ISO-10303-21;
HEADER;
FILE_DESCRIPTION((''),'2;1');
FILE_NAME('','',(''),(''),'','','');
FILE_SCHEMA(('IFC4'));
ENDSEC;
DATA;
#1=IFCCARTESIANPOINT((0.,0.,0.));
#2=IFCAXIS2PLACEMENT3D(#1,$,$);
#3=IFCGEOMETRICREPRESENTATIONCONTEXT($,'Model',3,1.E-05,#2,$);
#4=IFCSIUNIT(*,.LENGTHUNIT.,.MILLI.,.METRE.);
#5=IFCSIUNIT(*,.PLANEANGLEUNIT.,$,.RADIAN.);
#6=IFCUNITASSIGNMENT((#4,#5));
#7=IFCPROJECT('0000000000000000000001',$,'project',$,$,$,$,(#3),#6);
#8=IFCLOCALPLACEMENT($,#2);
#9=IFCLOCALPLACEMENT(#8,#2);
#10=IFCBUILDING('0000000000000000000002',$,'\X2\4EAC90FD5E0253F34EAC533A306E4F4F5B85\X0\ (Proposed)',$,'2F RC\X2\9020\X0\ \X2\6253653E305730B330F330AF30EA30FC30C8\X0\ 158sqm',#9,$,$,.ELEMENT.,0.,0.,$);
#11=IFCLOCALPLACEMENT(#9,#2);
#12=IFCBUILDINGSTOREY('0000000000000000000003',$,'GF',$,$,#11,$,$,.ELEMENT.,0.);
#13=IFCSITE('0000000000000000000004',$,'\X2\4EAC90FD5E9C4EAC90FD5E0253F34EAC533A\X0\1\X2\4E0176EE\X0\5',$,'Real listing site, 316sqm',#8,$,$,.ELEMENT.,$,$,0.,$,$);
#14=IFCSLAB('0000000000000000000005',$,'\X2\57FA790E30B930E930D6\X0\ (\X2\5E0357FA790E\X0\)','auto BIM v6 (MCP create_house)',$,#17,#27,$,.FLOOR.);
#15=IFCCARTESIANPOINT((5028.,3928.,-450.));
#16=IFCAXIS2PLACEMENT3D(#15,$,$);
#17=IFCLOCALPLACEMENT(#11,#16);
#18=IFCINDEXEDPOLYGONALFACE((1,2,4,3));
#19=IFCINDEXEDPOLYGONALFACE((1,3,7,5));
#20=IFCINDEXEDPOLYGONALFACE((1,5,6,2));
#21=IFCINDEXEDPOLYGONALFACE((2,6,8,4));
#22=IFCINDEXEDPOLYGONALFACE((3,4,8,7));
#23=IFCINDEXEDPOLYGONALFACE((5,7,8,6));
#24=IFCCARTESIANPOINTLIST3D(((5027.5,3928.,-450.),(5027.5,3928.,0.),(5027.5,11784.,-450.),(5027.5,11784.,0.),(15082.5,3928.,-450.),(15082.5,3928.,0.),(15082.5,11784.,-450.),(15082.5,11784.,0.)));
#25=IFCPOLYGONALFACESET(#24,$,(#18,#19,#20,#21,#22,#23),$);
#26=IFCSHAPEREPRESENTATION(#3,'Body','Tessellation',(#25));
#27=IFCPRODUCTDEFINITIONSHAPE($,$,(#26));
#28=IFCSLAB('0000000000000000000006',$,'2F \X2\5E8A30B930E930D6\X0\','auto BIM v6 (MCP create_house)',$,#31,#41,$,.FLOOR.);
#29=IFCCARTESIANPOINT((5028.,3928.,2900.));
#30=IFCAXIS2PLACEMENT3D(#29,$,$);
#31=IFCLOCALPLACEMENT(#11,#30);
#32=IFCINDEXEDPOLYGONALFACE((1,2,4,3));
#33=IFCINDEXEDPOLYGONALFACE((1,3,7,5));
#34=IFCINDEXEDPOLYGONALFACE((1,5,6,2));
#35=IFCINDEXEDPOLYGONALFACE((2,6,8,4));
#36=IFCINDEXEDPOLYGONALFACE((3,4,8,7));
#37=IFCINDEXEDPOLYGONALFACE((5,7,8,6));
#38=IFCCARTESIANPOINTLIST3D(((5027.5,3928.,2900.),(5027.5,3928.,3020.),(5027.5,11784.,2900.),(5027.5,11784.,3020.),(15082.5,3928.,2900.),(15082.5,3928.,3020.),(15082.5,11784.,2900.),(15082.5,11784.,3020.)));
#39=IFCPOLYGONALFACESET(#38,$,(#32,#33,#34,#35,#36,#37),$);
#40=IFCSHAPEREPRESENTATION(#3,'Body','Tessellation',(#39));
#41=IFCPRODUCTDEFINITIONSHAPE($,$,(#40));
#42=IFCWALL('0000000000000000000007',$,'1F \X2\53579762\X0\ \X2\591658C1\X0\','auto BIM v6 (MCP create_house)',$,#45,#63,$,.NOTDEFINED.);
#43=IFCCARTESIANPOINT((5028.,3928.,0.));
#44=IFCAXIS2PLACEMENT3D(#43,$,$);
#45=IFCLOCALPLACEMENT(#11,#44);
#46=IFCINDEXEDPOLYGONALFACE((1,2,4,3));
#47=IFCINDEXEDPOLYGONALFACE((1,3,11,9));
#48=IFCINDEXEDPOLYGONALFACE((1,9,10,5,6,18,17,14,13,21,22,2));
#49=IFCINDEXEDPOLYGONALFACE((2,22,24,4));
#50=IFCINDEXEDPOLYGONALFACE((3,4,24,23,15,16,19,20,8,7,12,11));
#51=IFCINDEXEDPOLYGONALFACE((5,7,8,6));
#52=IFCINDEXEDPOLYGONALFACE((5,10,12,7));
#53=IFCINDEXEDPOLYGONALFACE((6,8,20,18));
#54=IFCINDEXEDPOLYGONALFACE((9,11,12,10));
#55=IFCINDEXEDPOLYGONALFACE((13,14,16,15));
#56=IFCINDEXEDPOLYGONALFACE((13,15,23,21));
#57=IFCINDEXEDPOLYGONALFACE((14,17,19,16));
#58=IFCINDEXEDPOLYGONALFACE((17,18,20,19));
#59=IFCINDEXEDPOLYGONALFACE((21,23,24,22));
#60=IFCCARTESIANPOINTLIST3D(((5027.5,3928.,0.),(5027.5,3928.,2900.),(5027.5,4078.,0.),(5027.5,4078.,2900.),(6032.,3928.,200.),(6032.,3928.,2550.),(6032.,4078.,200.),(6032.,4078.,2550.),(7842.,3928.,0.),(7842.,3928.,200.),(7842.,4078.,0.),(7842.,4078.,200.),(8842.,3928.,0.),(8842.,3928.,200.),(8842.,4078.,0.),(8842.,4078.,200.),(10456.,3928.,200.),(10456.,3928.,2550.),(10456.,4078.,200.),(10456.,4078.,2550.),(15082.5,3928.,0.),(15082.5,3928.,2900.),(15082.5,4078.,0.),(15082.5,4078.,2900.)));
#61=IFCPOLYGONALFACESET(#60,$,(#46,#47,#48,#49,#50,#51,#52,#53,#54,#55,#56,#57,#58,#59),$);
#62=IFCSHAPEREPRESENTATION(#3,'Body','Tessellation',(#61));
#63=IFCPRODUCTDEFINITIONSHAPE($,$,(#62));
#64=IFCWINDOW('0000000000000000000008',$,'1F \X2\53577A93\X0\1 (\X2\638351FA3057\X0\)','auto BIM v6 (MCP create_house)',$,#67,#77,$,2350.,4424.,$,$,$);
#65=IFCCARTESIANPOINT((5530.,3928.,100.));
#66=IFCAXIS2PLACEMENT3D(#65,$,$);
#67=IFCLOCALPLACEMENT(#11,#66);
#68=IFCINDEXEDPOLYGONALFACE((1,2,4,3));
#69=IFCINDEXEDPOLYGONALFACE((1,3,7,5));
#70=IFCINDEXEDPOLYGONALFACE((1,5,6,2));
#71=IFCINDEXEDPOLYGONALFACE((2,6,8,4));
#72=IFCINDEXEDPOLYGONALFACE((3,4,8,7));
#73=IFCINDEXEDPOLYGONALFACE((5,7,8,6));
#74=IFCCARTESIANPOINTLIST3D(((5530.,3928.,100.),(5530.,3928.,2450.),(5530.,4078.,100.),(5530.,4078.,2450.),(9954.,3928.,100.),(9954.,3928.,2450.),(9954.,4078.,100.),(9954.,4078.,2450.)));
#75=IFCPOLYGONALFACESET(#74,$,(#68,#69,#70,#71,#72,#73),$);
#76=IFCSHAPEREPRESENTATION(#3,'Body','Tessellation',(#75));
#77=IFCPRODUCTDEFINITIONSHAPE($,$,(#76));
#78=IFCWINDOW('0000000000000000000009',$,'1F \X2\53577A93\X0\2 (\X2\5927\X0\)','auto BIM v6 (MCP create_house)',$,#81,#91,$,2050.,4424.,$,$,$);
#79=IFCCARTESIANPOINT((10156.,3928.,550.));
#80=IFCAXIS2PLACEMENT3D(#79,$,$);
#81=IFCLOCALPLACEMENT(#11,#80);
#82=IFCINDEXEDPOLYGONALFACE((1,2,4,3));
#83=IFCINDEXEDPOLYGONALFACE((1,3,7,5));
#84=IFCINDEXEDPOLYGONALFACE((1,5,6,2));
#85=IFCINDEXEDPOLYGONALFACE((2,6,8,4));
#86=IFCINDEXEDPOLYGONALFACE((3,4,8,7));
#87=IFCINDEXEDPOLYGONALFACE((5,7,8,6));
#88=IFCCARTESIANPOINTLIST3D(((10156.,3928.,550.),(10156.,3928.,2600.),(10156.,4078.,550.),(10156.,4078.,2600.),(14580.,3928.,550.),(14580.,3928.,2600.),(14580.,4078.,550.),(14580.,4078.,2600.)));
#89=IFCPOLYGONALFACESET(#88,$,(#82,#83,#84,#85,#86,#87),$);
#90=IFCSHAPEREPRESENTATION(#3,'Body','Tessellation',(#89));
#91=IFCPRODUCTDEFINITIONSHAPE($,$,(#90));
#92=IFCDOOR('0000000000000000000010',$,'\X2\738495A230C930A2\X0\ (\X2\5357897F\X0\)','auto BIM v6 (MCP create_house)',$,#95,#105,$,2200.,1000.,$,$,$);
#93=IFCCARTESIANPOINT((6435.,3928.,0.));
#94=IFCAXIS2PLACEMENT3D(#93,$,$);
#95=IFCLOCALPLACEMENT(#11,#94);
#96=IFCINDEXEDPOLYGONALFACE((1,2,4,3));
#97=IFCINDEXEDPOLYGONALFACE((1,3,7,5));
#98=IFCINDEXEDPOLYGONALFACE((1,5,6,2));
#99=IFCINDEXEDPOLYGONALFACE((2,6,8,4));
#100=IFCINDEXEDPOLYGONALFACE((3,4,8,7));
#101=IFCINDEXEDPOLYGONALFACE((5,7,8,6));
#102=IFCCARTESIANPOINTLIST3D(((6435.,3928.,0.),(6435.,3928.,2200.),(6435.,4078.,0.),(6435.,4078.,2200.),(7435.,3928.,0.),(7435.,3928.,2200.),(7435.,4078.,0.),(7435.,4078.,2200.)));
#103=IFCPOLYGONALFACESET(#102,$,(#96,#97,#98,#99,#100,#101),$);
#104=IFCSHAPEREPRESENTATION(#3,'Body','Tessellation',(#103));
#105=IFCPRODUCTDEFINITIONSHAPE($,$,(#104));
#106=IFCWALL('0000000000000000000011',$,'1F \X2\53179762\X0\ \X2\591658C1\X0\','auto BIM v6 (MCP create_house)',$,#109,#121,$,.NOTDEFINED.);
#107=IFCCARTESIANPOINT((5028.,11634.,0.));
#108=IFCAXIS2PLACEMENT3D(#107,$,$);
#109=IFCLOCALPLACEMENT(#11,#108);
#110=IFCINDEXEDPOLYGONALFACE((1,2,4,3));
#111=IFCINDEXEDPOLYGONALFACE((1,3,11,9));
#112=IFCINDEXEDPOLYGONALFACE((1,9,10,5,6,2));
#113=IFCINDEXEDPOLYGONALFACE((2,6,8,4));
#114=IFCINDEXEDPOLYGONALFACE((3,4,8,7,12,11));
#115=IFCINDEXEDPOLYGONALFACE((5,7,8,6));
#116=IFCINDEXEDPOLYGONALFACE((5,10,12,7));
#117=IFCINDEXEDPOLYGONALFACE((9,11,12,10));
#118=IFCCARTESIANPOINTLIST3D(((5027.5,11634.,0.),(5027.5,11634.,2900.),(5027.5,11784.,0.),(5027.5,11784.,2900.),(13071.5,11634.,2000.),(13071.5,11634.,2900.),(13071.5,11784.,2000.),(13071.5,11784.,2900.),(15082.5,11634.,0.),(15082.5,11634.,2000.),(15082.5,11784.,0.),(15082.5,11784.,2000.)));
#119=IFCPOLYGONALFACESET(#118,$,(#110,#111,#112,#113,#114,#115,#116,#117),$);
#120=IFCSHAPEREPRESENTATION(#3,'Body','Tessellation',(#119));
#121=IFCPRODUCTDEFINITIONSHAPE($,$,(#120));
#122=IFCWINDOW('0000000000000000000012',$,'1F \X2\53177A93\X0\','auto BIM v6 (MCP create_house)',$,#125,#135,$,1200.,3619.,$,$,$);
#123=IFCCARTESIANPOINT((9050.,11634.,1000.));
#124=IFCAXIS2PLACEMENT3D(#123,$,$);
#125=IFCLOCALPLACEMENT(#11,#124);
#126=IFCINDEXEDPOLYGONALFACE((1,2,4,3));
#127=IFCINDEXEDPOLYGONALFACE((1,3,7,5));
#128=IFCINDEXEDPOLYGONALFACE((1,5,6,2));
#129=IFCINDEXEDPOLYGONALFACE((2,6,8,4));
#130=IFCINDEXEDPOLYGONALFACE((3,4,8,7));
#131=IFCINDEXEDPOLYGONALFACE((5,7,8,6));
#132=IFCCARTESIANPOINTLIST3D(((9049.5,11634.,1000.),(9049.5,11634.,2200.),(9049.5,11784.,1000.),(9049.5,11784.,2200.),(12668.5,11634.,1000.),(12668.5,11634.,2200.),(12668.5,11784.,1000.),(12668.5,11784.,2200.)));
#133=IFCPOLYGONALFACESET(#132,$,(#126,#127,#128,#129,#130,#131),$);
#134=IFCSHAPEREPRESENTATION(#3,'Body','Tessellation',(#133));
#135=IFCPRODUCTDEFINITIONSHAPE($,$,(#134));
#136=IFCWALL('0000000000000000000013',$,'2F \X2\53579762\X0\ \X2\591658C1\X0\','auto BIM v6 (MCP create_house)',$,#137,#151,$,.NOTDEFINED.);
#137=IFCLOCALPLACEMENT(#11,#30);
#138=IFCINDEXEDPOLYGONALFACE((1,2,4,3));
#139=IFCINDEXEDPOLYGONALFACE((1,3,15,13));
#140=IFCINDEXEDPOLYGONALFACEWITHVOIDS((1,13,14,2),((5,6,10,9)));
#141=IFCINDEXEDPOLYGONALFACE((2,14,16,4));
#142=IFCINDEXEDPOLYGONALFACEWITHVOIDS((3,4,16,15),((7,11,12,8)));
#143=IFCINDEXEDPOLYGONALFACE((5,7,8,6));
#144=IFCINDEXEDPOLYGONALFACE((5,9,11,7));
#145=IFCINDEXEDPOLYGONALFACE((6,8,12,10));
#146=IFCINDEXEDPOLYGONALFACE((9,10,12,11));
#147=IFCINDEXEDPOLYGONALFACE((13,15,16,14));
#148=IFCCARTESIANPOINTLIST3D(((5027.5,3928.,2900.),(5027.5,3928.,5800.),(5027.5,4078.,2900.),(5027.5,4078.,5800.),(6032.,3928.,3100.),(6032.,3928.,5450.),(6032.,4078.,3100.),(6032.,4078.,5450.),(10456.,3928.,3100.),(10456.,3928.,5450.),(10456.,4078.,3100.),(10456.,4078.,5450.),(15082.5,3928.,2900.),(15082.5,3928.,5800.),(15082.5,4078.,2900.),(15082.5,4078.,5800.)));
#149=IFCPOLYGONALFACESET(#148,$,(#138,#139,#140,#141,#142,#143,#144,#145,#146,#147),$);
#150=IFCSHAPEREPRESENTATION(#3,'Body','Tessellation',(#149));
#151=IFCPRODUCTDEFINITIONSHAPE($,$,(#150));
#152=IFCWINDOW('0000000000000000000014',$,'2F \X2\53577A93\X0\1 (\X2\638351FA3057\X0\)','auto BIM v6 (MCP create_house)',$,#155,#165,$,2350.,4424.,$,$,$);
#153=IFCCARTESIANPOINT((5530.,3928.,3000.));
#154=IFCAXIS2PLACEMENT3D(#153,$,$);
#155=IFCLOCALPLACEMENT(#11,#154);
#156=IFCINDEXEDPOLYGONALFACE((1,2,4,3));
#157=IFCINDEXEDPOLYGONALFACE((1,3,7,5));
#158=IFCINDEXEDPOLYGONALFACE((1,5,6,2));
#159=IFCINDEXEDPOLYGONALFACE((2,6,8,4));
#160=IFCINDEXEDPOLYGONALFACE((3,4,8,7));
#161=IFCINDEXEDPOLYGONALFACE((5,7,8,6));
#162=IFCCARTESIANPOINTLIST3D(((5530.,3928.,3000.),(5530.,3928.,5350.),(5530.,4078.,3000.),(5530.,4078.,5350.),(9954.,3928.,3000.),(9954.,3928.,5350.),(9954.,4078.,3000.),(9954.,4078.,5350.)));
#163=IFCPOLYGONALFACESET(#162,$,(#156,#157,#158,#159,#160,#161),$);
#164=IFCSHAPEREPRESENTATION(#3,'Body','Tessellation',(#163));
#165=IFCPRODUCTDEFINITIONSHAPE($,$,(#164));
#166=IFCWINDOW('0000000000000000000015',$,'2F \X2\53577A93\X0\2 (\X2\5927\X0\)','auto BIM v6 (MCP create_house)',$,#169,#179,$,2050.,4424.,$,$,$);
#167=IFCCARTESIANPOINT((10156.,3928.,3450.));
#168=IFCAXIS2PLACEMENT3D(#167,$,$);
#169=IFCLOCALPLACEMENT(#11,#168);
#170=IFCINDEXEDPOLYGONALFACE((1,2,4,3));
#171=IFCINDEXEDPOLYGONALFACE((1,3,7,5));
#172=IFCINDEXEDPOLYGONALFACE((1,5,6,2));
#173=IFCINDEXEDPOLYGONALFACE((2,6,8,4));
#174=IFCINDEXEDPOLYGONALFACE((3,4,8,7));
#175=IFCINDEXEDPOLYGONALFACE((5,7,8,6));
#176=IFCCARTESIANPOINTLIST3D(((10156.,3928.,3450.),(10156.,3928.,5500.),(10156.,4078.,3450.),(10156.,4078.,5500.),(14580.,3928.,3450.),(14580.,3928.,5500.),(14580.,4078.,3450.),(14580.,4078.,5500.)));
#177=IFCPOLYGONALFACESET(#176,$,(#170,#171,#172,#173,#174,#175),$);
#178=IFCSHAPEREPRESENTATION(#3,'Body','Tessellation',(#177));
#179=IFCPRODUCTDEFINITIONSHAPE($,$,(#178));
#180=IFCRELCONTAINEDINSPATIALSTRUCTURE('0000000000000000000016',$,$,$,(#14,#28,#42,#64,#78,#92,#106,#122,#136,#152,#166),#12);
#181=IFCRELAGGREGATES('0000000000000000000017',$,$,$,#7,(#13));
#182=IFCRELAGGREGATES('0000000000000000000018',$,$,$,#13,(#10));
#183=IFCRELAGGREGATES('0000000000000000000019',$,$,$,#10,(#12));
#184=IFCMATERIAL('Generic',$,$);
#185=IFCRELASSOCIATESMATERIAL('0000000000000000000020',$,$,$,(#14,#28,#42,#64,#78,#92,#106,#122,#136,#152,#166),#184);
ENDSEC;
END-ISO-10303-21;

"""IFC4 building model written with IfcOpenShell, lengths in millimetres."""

from ifc_helpers import new_model, si_unit, frame, frame_2d, origin, place, context, project, spatial, rectangle, extrude, material, element, fill, save


model = new_model("IFC4")

# Units and contexts
model_context = context("Model", 3, precision=1e-05, world=origin())
ifc_project = project(units=[si_unit("LENGTHUNIT", "METRE", prefix="MILLI"), si_unit("PLANEANGLEUNIT", "RADIAN")], contexts=[model_context])

# Site, building, storey
site_placement = place(None, origin())
site = spatial("IfcSite", under=ifc_project, at=site_placement, Name="京都府京都市右京区1丁目5", ObjectType="Real listing site, 316sqm", CompositionType="ELEMENT", RefElevation=0.0)
building_placement = place(site_placement, origin())
building = spatial("IfcBuilding", under=site, at=building_placement, Name="京都市右京区の住宅 (Proposed)", ObjectType="2F RC造 打放しコンクリート 158sqm", CompositionType="ELEMENT", ElevationOfRefHeight=0.0, ElevationOfTerrain=0.0)
storey_placement = place(building_placement, origin())
storey = spatial("IfcBuildingStorey", under=building, at=storey_placement, Name="GF", CompositionType="ELEMENT", Elevation=0.0)

# Slabs
ifc_material = material(Name="Generic")
slab_1_placement = place(storey_placement, frame((5028.0, 3928.0, -450.0)))
element("IfcSlab", 1, at=slab_1_placement, inside=storey, material=ifc_material, Name="基礎スラブ (布基礎)", Description="auto BIM v6 (MCP create_house)", PredefinedType="FLOOR", context=model_context, shape_type="SweptSolid", body=[
    extrude(rectangle(XDim=10055.0, YDim=7856.0, at=frame_2d((5027.0, 3928.0))), frame((5028.0, 3928.0, -450.0)), (0.0, 0.0, 1.0), 450.0),
])
slab_2_placement = place(storey_placement, frame((5028.0, 3928.0, 2900.0)))
element("IfcSlab", 2, at=slab_2_placement, inside=storey, material=ifc_material, Name="2F 床スラブ", Description="auto BIM v6 (MCP create_house)", PredefinedType="FLOOR", context=model_context, shape_type="SweptSolid", body=[
    extrude(rectangle(XDim=10055.0, YDim=7856.0, at=frame_2d((5027.0, 3928.0))), frame((5028.0, 3928.0, 2900.0)), (0.0, 0.0, 1.0), 120.0),
])

# Wall, openings, windows, door
wall_1_placement = place(storey_placement, frame((5028.0, 3928.0, 0.0)))
wall_1 = element("IfcWall", 3, at=wall_1_placement, inside=storey, material=ifc_material, Name="1F 南面 外壁", Description="auto BIM v6 (MCP create_house)", PredefinedType="NOTDEFINED", context=model_context, shape_type="SweptSolid", body=[
    extrude(rectangle(XDim=10055.0, YDim=150.0, at=frame_2d((5027.0, 75.0))), frame((5028.0, 3928.0, 0.0)), (0.0, 0.0, 1.0), 2900.0),
])
opening_1_placement = place(storey_placement, frame((5530.0, 3928.0, 100.0)))
opening_1 = element("IfcOpeningElement", 4, at=opening_1_placement, cuts=wall_1, PredefinedType="NOTDEFINED", context=model_context, shape_type="SweptSolid", body=[
    extrude(rectangle(XDim=4424.0, YDim=150.0, at=frame_2d((2212.0, 75.0))), frame((5530.0, 3928.0, 100.0)), (0.0, 0.0, 1.0), 2350.0),
])
opening_2_placement = place(storey_placement, frame((10156.0, 3928.0, 550.0)))
opening_2 = element("IfcOpeningElement", 5, at=opening_2_placement, cuts=wall_1, PredefinedType="NOTDEFINED", context=model_context, shape_type="SweptSolid", body=[
    extrude(rectangle(XDim=4424.0, YDim=150.0, at=frame_2d((2212.0, 75.0))), frame((10156.0, 3928.0, 550.0)), (0.0, 0.0, 1.0), 2050.0),
])
opening_3_placement = place(storey_placement, frame((6435.0, 3928.0, 0.0)))
opening_3 = element("IfcOpeningElement", 6, at=opening_3_placement, cuts=wall_1, PredefinedType="NOTDEFINED", context=model_context, shape_type="SweptSolid", body=[
    extrude(rectangle(XDim=1000.0, YDim=150.0, at=frame_2d((500.0, 75.0))), frame((6435.0, 3928.0, 0.0)), (0.0, 0.0, 1.0), 2200.0),
])
window_1_placement = place(storey_placement, frame((5530.0, 3928.0, 100.0)))
window_1 = element("IfcWindow", 7, at=window_1_placement, inside=storey, material=ifc_material, Name="1F 南窓1 (掃出し)", Description="auto BIM v6 (MCP create_house)", OverallHeight=2350.0, OverallWidth=4424.0, context=model_context, shape_type="SweptSolid", body=[
    extrude(rectangle(XDim=4424.0, YDim=150.0, at=frame_2d((2212.0, 75.0))), frame((5530.0, 3928.0, 100.0)), (0.0, 0.0, 1.0), 2350.0),
])
fill(opening_1, window_1)
window_2_placement = place(storey_placement, frame((10156.0, 3928.0, 550.0)))
window_2 = element("IfcWindow", 8, at=window_2_placement, inside=storey, material=ifc_material, Name="1F 南窓2 (大)", Description="auto BIM v6 (MCP create_house)", OverallHeight=2050.0, OverallWidth=4424.0, context=model_context, shape_type="SweptSolid", body=[
    extrude(rectangle(XDim=4424.0, YDim=150.0, at=frame_2d((2212.0, 75.0))), frame((10156.0, 3928.0, 550.0)), (0.0, 0.0, 1.0), 2050.0),
])
fill(opening_2, window_2)
door_placement = place(storey_placement, frame((6435.0, 3928.0, 0.0)))
door = element("IfcDoor", 9, at=door_placement, inside=storey, material=ifc_material, Name="玄関ドア (南西)", Description="auto BIM v6 (MCP create_house)", OverallHeight=2200.0, OverallWidth=1000.0, context=model_context, shape_type="SweptSolid", body=[
    extrude(rectangle(XDim=1000.0, YDim=150.0, at=frame_2d((500.0, 75.0))), frame((6435.0, 3928.0, 0.0)), (0.0, 0.0, 1.0), 2200.0),
])
fill(opening_3, door)

# Wall, opening, window
wall_2_placement = place(storey_placement, frame((5028.0, 11634.0, 0.0)))
wall_2 = element("IfcWall", 10, at=wall_2_placement, inside=storey, material=ifc_material, Name="1F 北面 外壁", Description="auto BIM v6 (MCP create_house)", PredefinedType="NOTDEFINED", context=model_context, shape_type="SweptSolid", body=[
    extrude(rectangle(XDim=10055.0, YDim=150.0, at=frame_2d((5027.0, 75.0))), frame((5028.0, 11634.0, 0.0)), (0.0, 0.0, 1.0), 2900.0),
])
opening_4_placement = place(storey_placement, frame((9050.0, 11634.0, 1000.0)))
opening_4 = element("IfcOpeningElement", 11, at=opening_4_placement, cuts=wall_2, PredefinedType="NOTDEFINED", context=model_context, shape_type="SweptSolid", body=[
    extrude(rectangle(XDim=3619.0, YDim=150.0, at=frame_2d((1809.0, 75.0))), frame((9050.0, 11634.0, 1000.0)), (0.0, 0.0, 1.0), 1200.0),
])
window_3_placement = place(storey_placement, frame((9050.0, 11634.0, 1000.0)))
window_3 = element("IfcWindow", 12, at=window_3_placement, inside=storey, material=ifc_material, Name="1F 北窓", Description="auto BIM v6 (MCP create_house)", OverallHeight=1200.0, OverallWidth=3619.0, context=model_context, shape_type="SweptSolid", body=[
    extrude(rectangle(XDim=3619.0, YDim=150.0, at=frame_2d((1809.0, 75.0))), frame((9050.0, 11634.0, 1000.0)), (0.0, 0.0, 1.0), 1200.0),
])
fill(opening_4, window_3)

# Wall, openings, windows
wall_3_placement = place(storey_placement, frame((5028.0, 3928.0, 2900.0)))
wall_3 = element("IfcWall", 13, at=wall_3_placement, inside=storey, material=ifc_material, Name="2F 南面 外壁", Description="auto BIM v6 (MCP create_house)", PredefinedType="NOTDEFINED", context=model_context, shape_type="SweptSolid", body=[
    extrude(rectangle(XDim=10055.0, YDim=150.0, at=frame_2d((5027.0, 75.0))), frame((5028.0, 3928.0, 2900.0)), (0.0, 0.0, 1.0), 2900.0),
])
opening_5_placement = place(storey_placement, frame((5530.0, 3928.0, 3000.0)))
opening_5 = element("IfcOpeningElement", 14, at=opening_5_placement, cuts=wall_3, PredefinedType="NOTDEFINED", context=model_context, shape_type="SweptSolid", body=[
    extrude(rectangle(XDim=4424.0, YDim=150.0, at=frame_2d((2212.0, 75.0))), frame((5530.0, 3928.0, 3000.0)), (0.0, 0.0, 1.0), 2350.0),
])
opening_6_placement = place(storey_placement, frame((10156.0, 3928.0, 3450.0)))
opening_6 = element("IfcOpeningElement", 15, at=opening_6_placement, cuts=wall_3, PredefinedType="NOTDEFINED", context=model_context, shape_type="SweptSolid", body=[
    extrude(rectangle(XDim=4424.0, YDim=150.0, at=frame_2d((2212.0, 75.0))), frame((10156.0, 3928.0, 3450.0)), (0.0, 0.0, 1.0), 2050.0),
])
window_4_placement = place(storey_placement, frame((5530.0, 3928.0, 3000.0)))
window_4 = element("IfcWindow", 16, at=window_4_placement, inside=storey, material=ifc_material, Name="2F 南窓1 (掃出し)", Description="auto BIM v6 (MCP create_house)", OverallHeight=2350.0, OverallWidth=4424.0, context=model_context, shape_type="SweptSolid", body=[
    extrude(rectangle(XDim=4424.0, YDim=150.0, at=frame_2d((2212.0, 75.0))), frame((5530.0, 3928.0, 3000.0)), (0.0, 0.0, 1.0), 2350.0),
])
fill(opening_5, window_4)
window_5_placement = place(storey_placement, frame((10156.0, 3928.0, 3450.0)))
window_5 = element("IfcWindow", 17, at=window_5_placement, inside=storey, material=ifc_material, Name="2F 南窓2 (大)", Description="auto BIM v6 (MCP create_house)", OverallHeight=2050.0, OverallWidth=4424.0, context=model_context, shape_type="SweptSolid", body=[
    extrude(rectangle(XDim=4424.0, YDim=150.0, at=frame_2d((2212.0, 75.0))), frame((10156.0, 3928.0, 3450.0)), (0.0, 0.0, 1.0), 2050.0),
])
fill(opening_6, window_5)

save(model, "model.ifc")
